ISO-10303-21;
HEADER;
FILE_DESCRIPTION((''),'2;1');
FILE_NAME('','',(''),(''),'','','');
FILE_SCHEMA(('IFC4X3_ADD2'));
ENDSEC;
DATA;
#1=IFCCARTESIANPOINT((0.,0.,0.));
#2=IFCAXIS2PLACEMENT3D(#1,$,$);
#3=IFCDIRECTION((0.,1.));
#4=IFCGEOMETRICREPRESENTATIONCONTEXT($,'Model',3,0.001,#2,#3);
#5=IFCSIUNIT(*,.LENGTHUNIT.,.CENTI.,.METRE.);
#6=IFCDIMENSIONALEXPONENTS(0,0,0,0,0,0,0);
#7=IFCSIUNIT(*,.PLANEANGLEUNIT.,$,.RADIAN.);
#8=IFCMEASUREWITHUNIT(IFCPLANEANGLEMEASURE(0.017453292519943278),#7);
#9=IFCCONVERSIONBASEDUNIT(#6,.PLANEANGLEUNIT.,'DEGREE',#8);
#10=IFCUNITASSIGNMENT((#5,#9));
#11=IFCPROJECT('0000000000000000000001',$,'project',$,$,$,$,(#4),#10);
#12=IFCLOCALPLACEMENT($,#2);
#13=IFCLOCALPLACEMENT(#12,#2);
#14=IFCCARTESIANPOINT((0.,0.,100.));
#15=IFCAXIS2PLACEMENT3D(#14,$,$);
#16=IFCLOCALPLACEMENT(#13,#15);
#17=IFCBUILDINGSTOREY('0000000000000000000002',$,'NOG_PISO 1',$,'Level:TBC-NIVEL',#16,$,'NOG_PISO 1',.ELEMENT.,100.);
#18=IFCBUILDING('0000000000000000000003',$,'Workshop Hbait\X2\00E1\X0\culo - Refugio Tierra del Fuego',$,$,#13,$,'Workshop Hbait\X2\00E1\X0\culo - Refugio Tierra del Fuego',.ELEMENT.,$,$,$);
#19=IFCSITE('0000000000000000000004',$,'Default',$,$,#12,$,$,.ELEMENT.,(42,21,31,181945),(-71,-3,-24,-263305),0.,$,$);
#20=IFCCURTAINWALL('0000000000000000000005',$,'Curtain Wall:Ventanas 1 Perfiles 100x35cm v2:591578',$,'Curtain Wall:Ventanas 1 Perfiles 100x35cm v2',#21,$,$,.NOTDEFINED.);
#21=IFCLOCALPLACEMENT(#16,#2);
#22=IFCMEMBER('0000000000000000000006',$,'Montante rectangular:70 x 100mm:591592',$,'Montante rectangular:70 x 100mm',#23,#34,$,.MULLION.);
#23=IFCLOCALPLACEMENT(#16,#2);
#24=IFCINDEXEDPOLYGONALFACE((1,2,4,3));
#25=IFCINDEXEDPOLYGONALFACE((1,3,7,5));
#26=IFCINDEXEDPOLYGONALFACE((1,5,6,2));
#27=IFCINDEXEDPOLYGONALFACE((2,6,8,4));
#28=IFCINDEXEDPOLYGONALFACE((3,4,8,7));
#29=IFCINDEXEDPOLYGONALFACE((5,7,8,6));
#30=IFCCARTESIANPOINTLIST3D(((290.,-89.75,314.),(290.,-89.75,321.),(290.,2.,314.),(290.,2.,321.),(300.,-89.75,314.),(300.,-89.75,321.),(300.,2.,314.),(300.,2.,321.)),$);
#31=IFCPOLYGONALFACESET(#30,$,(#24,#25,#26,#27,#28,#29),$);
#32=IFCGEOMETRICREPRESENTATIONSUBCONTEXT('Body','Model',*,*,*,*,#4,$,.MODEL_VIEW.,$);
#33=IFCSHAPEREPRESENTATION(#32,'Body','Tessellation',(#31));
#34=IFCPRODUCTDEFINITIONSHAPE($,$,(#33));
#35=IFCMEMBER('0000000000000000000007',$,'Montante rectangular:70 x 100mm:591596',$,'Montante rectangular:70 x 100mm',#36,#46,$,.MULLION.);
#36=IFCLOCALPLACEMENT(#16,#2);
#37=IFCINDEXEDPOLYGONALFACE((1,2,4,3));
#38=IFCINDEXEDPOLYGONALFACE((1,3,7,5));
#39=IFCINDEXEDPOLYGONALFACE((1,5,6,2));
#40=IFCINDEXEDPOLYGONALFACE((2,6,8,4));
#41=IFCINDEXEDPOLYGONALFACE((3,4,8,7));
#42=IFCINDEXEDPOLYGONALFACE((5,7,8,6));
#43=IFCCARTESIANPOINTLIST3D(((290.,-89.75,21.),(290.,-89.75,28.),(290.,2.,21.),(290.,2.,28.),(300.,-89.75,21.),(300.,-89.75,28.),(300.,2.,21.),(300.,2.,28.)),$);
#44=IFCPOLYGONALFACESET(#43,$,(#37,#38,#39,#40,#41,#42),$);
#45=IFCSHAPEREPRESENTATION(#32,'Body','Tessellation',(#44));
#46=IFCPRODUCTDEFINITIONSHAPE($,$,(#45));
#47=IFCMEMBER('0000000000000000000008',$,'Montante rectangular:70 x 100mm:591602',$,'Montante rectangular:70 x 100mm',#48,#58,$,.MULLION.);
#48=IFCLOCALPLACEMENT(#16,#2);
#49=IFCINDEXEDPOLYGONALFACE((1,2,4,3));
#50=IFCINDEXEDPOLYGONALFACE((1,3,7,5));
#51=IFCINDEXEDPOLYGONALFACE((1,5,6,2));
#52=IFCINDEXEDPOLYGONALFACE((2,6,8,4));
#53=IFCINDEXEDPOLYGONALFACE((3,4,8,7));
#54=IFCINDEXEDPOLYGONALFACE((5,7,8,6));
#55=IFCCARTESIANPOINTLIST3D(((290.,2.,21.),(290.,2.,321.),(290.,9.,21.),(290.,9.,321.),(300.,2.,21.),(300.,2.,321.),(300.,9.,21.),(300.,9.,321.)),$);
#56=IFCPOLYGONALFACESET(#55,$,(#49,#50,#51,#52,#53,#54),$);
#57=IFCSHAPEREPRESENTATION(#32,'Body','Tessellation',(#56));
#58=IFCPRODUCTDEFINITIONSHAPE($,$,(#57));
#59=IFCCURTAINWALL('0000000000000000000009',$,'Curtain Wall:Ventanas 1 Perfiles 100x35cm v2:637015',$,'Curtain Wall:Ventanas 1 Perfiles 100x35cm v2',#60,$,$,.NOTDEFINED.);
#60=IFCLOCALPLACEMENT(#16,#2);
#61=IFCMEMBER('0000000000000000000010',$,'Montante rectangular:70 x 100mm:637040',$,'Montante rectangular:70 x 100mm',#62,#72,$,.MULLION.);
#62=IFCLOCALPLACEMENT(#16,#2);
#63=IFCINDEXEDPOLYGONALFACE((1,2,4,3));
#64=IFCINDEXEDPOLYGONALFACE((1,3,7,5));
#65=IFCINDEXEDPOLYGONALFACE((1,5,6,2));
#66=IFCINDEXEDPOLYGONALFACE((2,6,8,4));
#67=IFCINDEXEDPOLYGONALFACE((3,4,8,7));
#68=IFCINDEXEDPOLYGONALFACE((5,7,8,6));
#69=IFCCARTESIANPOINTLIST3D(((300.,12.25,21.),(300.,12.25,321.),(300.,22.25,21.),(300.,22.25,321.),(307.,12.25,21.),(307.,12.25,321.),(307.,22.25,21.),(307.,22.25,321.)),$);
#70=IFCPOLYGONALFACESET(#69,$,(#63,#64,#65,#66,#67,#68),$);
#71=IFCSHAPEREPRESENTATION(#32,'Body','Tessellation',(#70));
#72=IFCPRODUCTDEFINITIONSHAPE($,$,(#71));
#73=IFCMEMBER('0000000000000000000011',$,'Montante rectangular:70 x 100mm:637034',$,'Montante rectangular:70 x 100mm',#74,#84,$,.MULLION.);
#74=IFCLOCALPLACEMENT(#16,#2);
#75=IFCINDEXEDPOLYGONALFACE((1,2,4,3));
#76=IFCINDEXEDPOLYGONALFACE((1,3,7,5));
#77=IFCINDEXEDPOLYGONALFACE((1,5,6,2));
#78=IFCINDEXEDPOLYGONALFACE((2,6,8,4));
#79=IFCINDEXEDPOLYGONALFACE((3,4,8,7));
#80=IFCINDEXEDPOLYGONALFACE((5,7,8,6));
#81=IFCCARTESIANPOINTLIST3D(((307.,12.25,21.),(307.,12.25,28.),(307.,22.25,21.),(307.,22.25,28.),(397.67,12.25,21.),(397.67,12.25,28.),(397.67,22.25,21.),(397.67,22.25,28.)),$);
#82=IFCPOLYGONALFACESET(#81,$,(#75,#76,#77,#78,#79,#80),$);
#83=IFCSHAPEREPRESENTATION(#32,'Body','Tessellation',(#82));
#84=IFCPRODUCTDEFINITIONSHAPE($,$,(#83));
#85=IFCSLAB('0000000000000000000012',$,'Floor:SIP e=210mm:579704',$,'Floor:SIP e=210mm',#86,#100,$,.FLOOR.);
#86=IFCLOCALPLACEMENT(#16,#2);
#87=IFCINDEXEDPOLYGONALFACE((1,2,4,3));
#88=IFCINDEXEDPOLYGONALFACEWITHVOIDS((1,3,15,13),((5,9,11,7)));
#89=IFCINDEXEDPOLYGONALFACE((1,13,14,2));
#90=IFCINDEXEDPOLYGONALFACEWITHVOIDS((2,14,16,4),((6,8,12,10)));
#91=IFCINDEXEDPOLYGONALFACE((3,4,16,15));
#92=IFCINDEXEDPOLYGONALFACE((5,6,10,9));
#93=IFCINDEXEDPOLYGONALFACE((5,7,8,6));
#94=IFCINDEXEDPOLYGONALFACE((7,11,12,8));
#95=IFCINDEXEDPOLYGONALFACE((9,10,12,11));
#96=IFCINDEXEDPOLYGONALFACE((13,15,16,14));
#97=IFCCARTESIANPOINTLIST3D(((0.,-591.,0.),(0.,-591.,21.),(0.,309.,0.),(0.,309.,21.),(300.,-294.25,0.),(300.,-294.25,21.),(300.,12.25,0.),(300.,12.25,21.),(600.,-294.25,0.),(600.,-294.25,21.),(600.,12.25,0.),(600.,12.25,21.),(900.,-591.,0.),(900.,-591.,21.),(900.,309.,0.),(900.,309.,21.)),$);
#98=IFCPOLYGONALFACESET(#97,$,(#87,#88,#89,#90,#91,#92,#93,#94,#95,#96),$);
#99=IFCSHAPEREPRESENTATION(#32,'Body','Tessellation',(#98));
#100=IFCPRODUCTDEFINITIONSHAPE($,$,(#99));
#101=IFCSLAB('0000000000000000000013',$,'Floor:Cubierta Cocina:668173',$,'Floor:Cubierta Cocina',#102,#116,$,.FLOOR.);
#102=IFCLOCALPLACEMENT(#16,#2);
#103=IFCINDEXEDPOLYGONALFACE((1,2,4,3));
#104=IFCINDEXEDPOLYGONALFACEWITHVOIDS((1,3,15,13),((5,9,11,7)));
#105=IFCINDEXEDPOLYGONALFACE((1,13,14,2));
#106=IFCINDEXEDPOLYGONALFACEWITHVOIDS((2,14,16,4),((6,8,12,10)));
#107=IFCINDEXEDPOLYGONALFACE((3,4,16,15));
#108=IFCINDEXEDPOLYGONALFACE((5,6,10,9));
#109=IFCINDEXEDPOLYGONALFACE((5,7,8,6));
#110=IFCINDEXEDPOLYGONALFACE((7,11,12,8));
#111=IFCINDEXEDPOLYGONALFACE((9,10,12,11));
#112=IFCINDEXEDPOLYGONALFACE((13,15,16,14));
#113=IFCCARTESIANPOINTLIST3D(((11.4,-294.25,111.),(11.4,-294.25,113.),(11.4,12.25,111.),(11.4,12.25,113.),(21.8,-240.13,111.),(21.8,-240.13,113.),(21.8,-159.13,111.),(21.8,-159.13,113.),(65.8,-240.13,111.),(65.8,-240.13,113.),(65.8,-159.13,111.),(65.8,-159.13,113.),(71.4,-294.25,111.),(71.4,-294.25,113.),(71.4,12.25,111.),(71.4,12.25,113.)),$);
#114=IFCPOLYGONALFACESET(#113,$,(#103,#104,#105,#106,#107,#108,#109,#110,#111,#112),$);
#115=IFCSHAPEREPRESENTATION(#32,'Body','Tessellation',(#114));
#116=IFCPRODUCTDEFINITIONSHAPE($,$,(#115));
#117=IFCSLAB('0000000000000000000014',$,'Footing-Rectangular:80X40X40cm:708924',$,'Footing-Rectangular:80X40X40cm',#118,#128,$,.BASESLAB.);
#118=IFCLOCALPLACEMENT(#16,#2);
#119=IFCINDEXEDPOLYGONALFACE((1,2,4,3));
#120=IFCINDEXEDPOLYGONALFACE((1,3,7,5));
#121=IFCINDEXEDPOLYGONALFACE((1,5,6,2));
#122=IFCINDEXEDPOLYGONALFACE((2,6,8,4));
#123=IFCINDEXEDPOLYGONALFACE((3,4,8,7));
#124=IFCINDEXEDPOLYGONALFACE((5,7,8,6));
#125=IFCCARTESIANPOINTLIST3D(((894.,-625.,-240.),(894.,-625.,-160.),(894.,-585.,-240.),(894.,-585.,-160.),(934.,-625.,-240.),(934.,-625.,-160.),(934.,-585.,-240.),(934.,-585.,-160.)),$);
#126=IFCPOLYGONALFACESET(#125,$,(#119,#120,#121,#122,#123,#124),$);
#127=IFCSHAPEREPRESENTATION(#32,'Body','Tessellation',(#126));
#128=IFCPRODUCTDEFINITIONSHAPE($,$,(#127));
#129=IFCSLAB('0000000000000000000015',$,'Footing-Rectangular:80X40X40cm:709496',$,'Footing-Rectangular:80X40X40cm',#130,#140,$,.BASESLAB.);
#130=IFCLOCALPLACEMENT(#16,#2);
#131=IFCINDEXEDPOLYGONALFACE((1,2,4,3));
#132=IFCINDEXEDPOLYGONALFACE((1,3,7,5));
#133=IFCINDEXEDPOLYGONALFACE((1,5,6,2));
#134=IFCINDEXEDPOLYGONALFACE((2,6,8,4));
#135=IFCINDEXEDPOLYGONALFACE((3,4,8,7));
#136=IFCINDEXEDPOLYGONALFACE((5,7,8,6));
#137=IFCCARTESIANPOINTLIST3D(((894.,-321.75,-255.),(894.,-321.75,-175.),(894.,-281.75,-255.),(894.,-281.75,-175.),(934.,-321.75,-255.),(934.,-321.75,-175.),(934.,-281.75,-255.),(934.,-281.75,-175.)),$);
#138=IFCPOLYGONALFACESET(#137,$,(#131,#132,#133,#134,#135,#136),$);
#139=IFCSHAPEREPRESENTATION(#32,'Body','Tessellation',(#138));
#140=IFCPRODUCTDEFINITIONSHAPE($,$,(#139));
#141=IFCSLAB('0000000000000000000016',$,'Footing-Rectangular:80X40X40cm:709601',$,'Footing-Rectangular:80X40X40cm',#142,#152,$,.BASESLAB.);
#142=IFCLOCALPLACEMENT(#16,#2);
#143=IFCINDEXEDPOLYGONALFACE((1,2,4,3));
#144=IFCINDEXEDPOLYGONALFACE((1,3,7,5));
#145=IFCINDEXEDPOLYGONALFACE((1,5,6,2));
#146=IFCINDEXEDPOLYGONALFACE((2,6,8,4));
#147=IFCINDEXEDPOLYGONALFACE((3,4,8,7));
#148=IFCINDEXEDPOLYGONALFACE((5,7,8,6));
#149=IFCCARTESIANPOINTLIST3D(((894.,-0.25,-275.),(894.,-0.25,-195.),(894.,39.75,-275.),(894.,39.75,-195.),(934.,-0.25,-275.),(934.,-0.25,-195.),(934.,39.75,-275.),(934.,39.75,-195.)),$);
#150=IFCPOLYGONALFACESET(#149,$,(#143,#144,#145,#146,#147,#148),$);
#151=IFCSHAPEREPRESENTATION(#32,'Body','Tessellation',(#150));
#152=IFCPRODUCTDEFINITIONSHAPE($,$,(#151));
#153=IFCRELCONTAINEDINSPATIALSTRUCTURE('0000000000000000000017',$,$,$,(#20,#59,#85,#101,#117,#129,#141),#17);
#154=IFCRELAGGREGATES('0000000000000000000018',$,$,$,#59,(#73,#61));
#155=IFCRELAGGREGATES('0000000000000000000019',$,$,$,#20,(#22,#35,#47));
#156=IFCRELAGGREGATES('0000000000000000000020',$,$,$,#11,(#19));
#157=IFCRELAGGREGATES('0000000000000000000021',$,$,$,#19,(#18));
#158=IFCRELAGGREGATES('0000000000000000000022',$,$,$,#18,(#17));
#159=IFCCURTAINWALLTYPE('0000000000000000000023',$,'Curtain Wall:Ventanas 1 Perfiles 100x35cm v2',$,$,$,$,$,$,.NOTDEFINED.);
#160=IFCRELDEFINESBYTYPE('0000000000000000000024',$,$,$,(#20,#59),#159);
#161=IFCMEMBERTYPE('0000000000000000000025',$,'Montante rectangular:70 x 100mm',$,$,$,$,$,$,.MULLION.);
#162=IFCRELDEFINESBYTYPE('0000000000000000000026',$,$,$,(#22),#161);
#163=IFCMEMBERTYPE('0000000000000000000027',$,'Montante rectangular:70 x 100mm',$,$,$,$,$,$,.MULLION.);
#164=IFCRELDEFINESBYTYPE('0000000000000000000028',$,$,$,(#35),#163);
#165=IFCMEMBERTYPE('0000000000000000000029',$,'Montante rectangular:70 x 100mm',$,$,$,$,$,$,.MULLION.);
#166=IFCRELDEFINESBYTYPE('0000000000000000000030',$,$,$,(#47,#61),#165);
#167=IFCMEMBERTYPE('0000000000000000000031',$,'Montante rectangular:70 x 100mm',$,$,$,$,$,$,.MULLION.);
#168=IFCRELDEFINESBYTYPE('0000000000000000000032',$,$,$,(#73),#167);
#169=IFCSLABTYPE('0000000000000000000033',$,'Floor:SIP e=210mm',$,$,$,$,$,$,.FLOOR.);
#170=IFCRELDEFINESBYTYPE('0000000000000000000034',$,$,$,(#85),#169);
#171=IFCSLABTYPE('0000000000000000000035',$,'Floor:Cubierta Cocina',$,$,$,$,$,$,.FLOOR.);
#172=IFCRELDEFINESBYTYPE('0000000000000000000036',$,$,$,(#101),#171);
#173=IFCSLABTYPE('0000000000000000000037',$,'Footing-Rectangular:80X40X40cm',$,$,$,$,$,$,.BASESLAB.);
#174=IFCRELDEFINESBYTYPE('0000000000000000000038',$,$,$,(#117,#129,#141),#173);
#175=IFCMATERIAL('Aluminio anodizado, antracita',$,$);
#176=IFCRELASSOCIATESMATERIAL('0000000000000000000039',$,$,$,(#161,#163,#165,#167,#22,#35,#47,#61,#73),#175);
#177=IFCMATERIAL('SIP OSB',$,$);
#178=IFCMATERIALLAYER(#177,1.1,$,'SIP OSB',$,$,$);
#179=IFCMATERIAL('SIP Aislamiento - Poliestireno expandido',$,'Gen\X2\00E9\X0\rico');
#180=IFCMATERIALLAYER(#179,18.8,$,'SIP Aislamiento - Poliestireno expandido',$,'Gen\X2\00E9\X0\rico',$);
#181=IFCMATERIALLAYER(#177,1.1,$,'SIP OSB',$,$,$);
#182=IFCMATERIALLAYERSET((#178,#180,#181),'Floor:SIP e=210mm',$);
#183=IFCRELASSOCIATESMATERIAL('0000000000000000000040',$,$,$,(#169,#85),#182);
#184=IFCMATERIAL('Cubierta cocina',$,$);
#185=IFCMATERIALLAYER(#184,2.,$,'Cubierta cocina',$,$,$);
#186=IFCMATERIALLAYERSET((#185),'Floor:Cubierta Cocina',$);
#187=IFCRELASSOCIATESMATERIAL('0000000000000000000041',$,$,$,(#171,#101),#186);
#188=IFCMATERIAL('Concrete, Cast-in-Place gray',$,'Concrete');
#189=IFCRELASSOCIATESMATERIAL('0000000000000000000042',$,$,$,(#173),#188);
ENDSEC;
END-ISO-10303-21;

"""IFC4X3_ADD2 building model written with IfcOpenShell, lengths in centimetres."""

from ifc_helpers import new_model, entity, si_unit, converted_unit, direction, frame, frame_2d, origin, origin_2d_with_axis, place, context, subcontext, project, spatial, rectangle, extrude, boolean, source, transform, mapped, material, layer, layer_set, layer_usage, material_profile, profile_set, profile_usage, type_object, type_shapes, element, aggregate, save


model = new_model("IFC4X3_ADD2")

# Units and contexts
model_context = context("Model", 3, precision=0.001, world=origin(), true_north=direction((0.0, 1.0)))
body_context = subcontext(model_context, "Body", "Model", "MODEL_VIEW")
ifc_project = project(units=[si_unit("LENGTHUNIT", "METRE", prefix="CENTI"), converted_unit("PLANEANGLEUNIT", "DEGREE", entity("IfcPlaneAngleMeasure", 0.017453292519943278), si_unit("PLANEANGLEUNIT", "RADIAN"), dimensions=[0, 0, 0, 0, 0, 0, 0])], contexts=[model_context])

# Site, building, storey
site_placement = place(None, origin())
site = spatial("IfcSite", under=ifc_project, at=site_placement, Name="Default", CompositionType="ELEMENT", RefLatitude=(42, 21, 31, 181945), RefLongitude=(-71, -3, -24, -263305), RefElevation=0.0)
building_placement = place(site_placement, origin())
building = spatial("IfcBuilding", under=site, at=building_placement, Name="Workshop Hbaitáculo - Refugio Tierra del Fuego", LongName="Workshop Hbaitáculo - Refugio Tierra del Fuego", CompositionType="ELEMENT")
storey_placement = place(building_placement, frame((0.0, 0.0, 100.0)))
storey = spatial("IfcBuildingStorey", under=building, at=storey_placement, Name="NOG_PISO 1", ObjectType="Level:TBC-NIVEL", LongName="NOG_PISO 1", CompositionType="ELEMENT", Elevation=100.0)

# Curtain walls, members
curtain_wall_type = type_object("IfcCurtainWallType", Name="Curtain Wall:Ventanas 1 Perfiles 100x35cm v2", PredefinedType="NOTDEFINED")
curtain_wall_1_placement = place(storey_placement, frame((0.0, 0.0, -100.0)))
curtain_wall_1 = element("IfcCurtainWall", 1, at=curtain_wall_1_placement, inside=storey, type_object=curtain_wall_type, Name="Curtain Wall:Ventanas 1 Perfiles 100x35cm v2:591578", ObjectType="Curtain Wall:Ventanas 1 Perfiles 100x35cm v2", PredefinedType="NOTDEFINED")
ifc_material_1 = material(Name="Aluminio anodizado, antracita")
ifc_material_profile_1 = material_profile(ifc_material_1, rectangle(XDim=7.0, YDim=10.0, at=origin_2d_with_axis()), Name="70 x 100mm")
ifc_profile_set_1 = profile_set([ifc_material_profile_1], Name="70 x 100mm")
ifc_profile_usage_1 = profile_usage(ifc_profile_set_1)
member_type_1 = type_object("IfcMemberType", Name="Montante rectangular:70 x 100mm", PredefinedType="MULLION", material=ifc_profile_set_1)
shared_shape_1 = source(origin(), body_context, "Body", "SweptSolid", [
    extrude(rectangle(XDim=7.0, YDim=10.0, at=origin_2d_with_axis()), frame((-3.5, 0.0, -91.75), z_axis=(0.0, 0.0, 1.0), x_axis=(-1.0, 0.0, 0.0)), (0.0, 0.0, 1.0), 91.75),
])
type_shapes(member_type_1, [shared_shape_1])
member_1_placement = place(curtain_wall_1_placement, frame((295.0, -89.75, 421.0), z_axis=(0.0, -1.0, 0.0), x_axis=(0.0, 0.0, 1.0)))
member_1 = element("IfcMember", 2, at=member_1_placement, type_object=member_type_1, material=ifc_profile_usage_1, Name="Montante rectangular:70 x 100mm:591592", ObjectType="Montante rectangular:70 x 100mm", PredefinedType="MULLION", context=body_context, shape_type="MappedRepresentation", body=[
    mapped(shared_shape_1, transform((0.0, 0.0, 0.0), scale=1.0)),
])
member_type_2 = type_object("IfcMemberType", Name="Montante rectangular:70 x 100mm", PredefinedType="MULLION", material=ifc_profile_set_1)
shared_shape_2 = source(origin(), body_context, "Body", "SweptSolid", [
    extrude(rectangle(XDim=7.0, YDim=10.0, at=origin_2d_with_axis()), frame((-3.5, 0.0, -91.75), z_axis=(0.0, 0.0, 1.0), x_axis=(-1.0, 0.0, 0.0)), (0.0, 0.0, 1.0), 91.75),
])
type_shapes(member_type_2, [shared_shape_2])
member_2_placement = place(curtain_wall_1_placement, frame((295.0, 2.0, 121.0), z_axis=(0.0, 1.0, 0.0), x_axis=(0.0, 0.0, -1.0)))
member_2 = element("IfcMember", 3, at=member_2_placement, type_object=member_type_2, material=ifc_profile_usage_1, Name="Montante rectangular:70 x 100mm:591596", ObjectType="Montante rectangular:70 x 100mm", PredefinedType="MULLION", context=body_context, shape_type="MappedRepresentation", body=[
    mapped(shared_shape_2, transform((0.0, 0.0, 0.0), scale=1.0)),
])
member_type_3 = type_object("IfcMemberType", Name="Montante rectangular:70 x 100mm", PredefinedType="MULLION", material=ifc_profile_set_1)
shared_shape_3 = source(origin(), body_context, "Body", "SweptSolid", [
    extrude(rectangle(XDim=7.0, YDim=10.0, at=origin_2d_with_axis()), frame((-3.5, 0.0, -300.0), z_axis=(0.0, 0.0, 1.0), x_axis=(-1.0, 0.0, 0.0)), (0.0, 0.0, 1.0), 300.0),
])
type_shapes(member_type_3, [shared_shape_3])
member_3_placement = place(curtain_wall_1_placement, frame((295.0, 9.0, 421.0), z_axis=(0.0, 0.0, 1.0), x_axis=(0.0, 1.0, 0.0)))
member_3 = element("IfcMember", 4, at=member_3_placement, type_object=member_type_3, material=ifc_profile_usage_1, Name="Montante rectangular:70 x 100mm:591602", ObjectType="Montante rectangular:70 x 100mm", PredefinedType="MULLION", context=body_context, shape_type="MappedRepresentation", body=[
    mapped(shared_shape_3, transform((0.0, 0.0, 0.0), scale=1.0)),
])
curtain_wall_2_placement = place(storey_placement, frame((0.0, 0.0, -100.0)))
curtain_wall_2 = element("IfcCurtainWall", 5, at=curtain_wall_2_placement, inside=storey, type_object=curtain_wall_type, Name="Curtain Wall:Ventanas 1 Perfiles 100x35cm v2:637015", ObjectType="Curtain Wall:Ventanas 1 Perfiles 100x35cm v2", PredefinedType="NOTDEFINED")
member_4_placement = place(curtain_wall_2_placement, frame((300.0, 17.25, 421.0), z_axis=(0.0, 0.0, 1.0), x_axis=(-1.0, 0.0, 0.0)))
member_4 = element("IfcMember", 6, at=member_4_placement, type_object=member_type_3, material=ifc_profile_usage_1, Name="Montante rectangular:70 x 100mm:637040", ObjectType="Montante rectangular:70 x 100mm", PredefinedType="MULLION", context=body_context, shape_type="MappedRepresentation", body=[
    mapped(shared_shape_3, transform((0.0, 0.0, 0.0), scale=1.0)),
])
member_type_4 = type_object("IfcMemberType", Name="Montante rectangular:70 x 100mm", PredefinedType="MULLION", material=ifc_profile_set_1)
shared_shape_4 = source(origin(), body_context, "Body", "SweptSolid", [
    extrude(rectangle(XDim=7.0, YDim=10.0, at=origin_2d_with_axis()), frame((-3.5, 0.0, -90.67), z_axis=(0.0, 0.0, 1.0), x_axis=(-1.0, 0.0, 0.0)), (0.0, 0.0, 1.0), 90.67),
])
type_shapes(member_type_4, [shared_shape_4])
member_5_placement = place(curtain_wall_2_placement, frame((307.0, 17.25, 121.0), z_axis=(-1.0, 0.0, 0.0), x_axis=(0.0, 0.0, -1.0)))
member_5 = element("IfcMember", 7, at=member_5_placement, type_object=member_type_4, material=ifc_profile_usage_1, Name="Montante rectangular:70 x 100mm:637034", ObjectType="Montante rectangular:70 x 100mm", PredefinedType="MULLION", context=body_context, shape_type="MappedRepresentation", body=[
    mapped(shared_shape_4, transform((0.0, 0.0, 0.0), scale=1.0)),
])
aggregate(curtain_wall_2, [member_5, member_4])

# Slab, opening
ifc_material_2 = material(Name="SIP OSB")
ifc_layer_1 = layer(ifc_material_2, 1.1, Name="SIP OSB")
ifc_material_3 = material(Name="SIP Aislamiento - Poliestireno expandido", Category="Genérico")
ifc_layer_2 = layer(ifc_material_3, 18.8, Name="SIP Aislamiento - Poliestireno expandido", Category="Genérico")
ifc_layer_3 = layer(ifc_material_2, 1.1, Name="SIP OSB")
ifc_layer_set_1 = layer_set([ifc_layer_1, ifc_layer_2, ifc_layer_3], Name="Floor:SIP e=210mm")
ifc_layer_usage_1 = layer_usage(ifc_layer_set_1, "AXIS3", "POSITIVE", 0.0)
slab_type_1 = type_object("IfcSlabType", Name="Floor:SIP e=210mm", PredefinedType="FLOOR", material=ifc_layer_set_1)
slab_1_placement = place(storey_placement, origin())
slab_1 = element("IfcSlab", 8, at=slab_1_placement, inside=storey, type_object=slab_type_1, material=ifc_layer_usage_1, Name="Floor:SIP e=210mm:579704", ObjectType="Floor:SIP e=210mm", PredefinedType="FLOOR", context=body_context, shape_type="CSG", body=[
    boolean("DIFFERENCE", extrude(rectangle(XDim=900.0, YDim=900.0, at=origin_2d_with_axis()), frame((450.0, -141.0, 21.0), z_axis=(0.0, 0.0, -1.0), x_axis=(0.0, 1.0, 0.0)), (0.0, 0.0, 1.0), 21.0), extrude(rectangle(XDim=306.5, YDim=300.0, at=frame_2d((0.0, 0.0), x_axis=(1.0, 0.0))), frame((450.0, -141.0, 0.0), z_axis=(0.0, 0.0, 1.0), x_axis=(0.0, 1.0, 0.0)), (0.0, 0.0, 1.0), 21.0)),
])
opening_1_placement = place(slab_1_placement, origin())
element("IfcOpeningElement", 9, at=opening_1_placement, cuts=slab_1, PredefinedType="OPENING", context=body_context, shape_type="SweptSolid", body=[
    extrude(rectangle(XDim=306.5, YDim=300.0, at=frame_2d((450.0, -141.0), x_axis=(0.0, -1.0))), frame((0.0, 0.0, 21.0)), (0.0, 0.0, -1.0), 21.0),
])

aggregate(curtain_wall_1, [member_1, member_2, member_3])

# Slab, opening
ifc_material_4 = material(Name="Cubierta cocina")
ifc_layer_4 = layer(ifc_material_4, 2.0, Name="Cubierta cocina")
ifc_layer_set_2 = layer_set([ifc_layer_4], Name="Floor:Cubierta Cocina")
ifc_layer_usage_2 = layer_usage(ifc_layer_set_2, "AXIS3", "POSITIVE", 0.0)
slab_type_2 = type_object("IfcSlabType", Name="Floor:Cubierta Cocina", PredefinedType="FLOOR", material=ifc_layer_set_2)
slab_2_placement = place(storey_placement, origin())
slab_2 = element("IfcSlab", 10, at=slab_2_placement, inside=storey, type_object=slab_type_2, material=ifc_layer_usage_2, Name="Floor:Cubierta Cocina:668173", ObjectType="Floor:Cubierta Cocina", PredefinedType="FLOOR", context=body_context, shape_type="CSG", body=[
    boolean("DIFFERENCE", extrude(rectangle(XDim=306.5, YDim=60.0, at=origin_2d_with_axis()), frame((41.4, -141.0, 113.0), z_axis=(0.0, 0.0, -1.0), x_axis=(0.0, 1.0, 0.0)), (0.0, 0.0, 1.0), 2.0), extrude(rectangle(XDim=81.0, YDim=44.0, at=frame_2d((0.0, 0.0), x_axis=(1.0, 0.0))), frame((43.8, -199.63, 111.0), z_axis=(0.0, 0.0, 1.0), x_axis=(0.0, 1.0, 0.0)), (0.0, 0.0, 1.0), 2.0)),
])
opening_2_placement = place(slab_2_placement, origin())
element("IfcOpeningElement", 11, at=opening_2_placement, cuts=slab_2, PredefinedType="OPENING", context=body_context, shape_type="SweptSolid", body=[
    extrude(rectangle(XDim=81.0, YDim=44.0, at=frame_2d((43.8, -199.63), x_axis=(0.0, 1.0))), frame((0.0, 0.0, 113.0)), (0.0, 0.0, -1.0), 2.0),
])

# Slabs
ifc_material_5 = material(Name="Concrete, Cast-in-Place gray", Category="Concrete")
slab_type_3 = type_object("IfcSlabType", Name="Footing-Rectangular:80X40X40cm", PredefinedType="BASESLAB", material=ifc_material_5)
slab_3_placement = place(storey_placement, frame((0.0, 0.0, -160.0)))
element("IfcSlab", 12, at=slab_3_placement, inside=storey, type_object=slab_type_3, Name="Footing-Rectangular:80X40X40cm:708924", ObjectType="Footing-Rectangular:80X40X40cm", PredefinedType="BASESLAB", context=body_context, shape_type="SweptSolid", body=[
    extrude(rectangle(XDim=40.0, YDim=40.0, at=origin_2d_with_axis()), frame((914.0, -605.0, -80.0), z_axis=(0.0, 0.0, 1.0), x_axis=(-1.0, 0.0, 0.0)), (0.0, 0.0, 1.0), 80.0),
])
slab_4_placement = place(storey_placement, frame((0.0, 0.0, -175.0)))
element("IfcSlab", 13, at=slab_4_placement, inside=storey, type_object=slab_type_3, Name="Footing-Rectangular:80X40X40cm:709496", ObjectType="Footing-Rectangular:80X40X40cm", PredefinedType="BASESLAB", context=body_context, shape_type="SweptSolid", body=[
    extrude(rectangle(XDim=40.0, YDim=40.0, at=origin_2d_with_axis()), frame((914.0, -301.75, -80.0), z_axis=(0.0, 0.0, 1.0), x_axis=(-1.0, 0.0, 0.0)), (0.0, 0.0, 1.0), 80.0),
])
slab_5_placement = place(storey_placement, frame((0.0, 0.0, -195.0)))
element("IfcSlab", 14, at=slab_5_placement, inside=storey, type_object=slab_type_3, Name="Footing-Rectangular:80X40X40cm:709601", ObjectType="Footing-Rectangular:80X40X40cm", PredefinedType="BASESLAB", context=body_context, shape_type="SweptSolid", body=[
    extrude(rectangle(XDim=40.0, YDim=40.0, at=origin_2d_with_axis()), frame((914.0, 19.75, -80.0), z_axis=(0.0, 0.0, 1.0), x_axis=(-1.0, 0.0, 0.0)), (0.0, 0.0, 1.0), 80.0),
])

save(model, "model.ifc")
